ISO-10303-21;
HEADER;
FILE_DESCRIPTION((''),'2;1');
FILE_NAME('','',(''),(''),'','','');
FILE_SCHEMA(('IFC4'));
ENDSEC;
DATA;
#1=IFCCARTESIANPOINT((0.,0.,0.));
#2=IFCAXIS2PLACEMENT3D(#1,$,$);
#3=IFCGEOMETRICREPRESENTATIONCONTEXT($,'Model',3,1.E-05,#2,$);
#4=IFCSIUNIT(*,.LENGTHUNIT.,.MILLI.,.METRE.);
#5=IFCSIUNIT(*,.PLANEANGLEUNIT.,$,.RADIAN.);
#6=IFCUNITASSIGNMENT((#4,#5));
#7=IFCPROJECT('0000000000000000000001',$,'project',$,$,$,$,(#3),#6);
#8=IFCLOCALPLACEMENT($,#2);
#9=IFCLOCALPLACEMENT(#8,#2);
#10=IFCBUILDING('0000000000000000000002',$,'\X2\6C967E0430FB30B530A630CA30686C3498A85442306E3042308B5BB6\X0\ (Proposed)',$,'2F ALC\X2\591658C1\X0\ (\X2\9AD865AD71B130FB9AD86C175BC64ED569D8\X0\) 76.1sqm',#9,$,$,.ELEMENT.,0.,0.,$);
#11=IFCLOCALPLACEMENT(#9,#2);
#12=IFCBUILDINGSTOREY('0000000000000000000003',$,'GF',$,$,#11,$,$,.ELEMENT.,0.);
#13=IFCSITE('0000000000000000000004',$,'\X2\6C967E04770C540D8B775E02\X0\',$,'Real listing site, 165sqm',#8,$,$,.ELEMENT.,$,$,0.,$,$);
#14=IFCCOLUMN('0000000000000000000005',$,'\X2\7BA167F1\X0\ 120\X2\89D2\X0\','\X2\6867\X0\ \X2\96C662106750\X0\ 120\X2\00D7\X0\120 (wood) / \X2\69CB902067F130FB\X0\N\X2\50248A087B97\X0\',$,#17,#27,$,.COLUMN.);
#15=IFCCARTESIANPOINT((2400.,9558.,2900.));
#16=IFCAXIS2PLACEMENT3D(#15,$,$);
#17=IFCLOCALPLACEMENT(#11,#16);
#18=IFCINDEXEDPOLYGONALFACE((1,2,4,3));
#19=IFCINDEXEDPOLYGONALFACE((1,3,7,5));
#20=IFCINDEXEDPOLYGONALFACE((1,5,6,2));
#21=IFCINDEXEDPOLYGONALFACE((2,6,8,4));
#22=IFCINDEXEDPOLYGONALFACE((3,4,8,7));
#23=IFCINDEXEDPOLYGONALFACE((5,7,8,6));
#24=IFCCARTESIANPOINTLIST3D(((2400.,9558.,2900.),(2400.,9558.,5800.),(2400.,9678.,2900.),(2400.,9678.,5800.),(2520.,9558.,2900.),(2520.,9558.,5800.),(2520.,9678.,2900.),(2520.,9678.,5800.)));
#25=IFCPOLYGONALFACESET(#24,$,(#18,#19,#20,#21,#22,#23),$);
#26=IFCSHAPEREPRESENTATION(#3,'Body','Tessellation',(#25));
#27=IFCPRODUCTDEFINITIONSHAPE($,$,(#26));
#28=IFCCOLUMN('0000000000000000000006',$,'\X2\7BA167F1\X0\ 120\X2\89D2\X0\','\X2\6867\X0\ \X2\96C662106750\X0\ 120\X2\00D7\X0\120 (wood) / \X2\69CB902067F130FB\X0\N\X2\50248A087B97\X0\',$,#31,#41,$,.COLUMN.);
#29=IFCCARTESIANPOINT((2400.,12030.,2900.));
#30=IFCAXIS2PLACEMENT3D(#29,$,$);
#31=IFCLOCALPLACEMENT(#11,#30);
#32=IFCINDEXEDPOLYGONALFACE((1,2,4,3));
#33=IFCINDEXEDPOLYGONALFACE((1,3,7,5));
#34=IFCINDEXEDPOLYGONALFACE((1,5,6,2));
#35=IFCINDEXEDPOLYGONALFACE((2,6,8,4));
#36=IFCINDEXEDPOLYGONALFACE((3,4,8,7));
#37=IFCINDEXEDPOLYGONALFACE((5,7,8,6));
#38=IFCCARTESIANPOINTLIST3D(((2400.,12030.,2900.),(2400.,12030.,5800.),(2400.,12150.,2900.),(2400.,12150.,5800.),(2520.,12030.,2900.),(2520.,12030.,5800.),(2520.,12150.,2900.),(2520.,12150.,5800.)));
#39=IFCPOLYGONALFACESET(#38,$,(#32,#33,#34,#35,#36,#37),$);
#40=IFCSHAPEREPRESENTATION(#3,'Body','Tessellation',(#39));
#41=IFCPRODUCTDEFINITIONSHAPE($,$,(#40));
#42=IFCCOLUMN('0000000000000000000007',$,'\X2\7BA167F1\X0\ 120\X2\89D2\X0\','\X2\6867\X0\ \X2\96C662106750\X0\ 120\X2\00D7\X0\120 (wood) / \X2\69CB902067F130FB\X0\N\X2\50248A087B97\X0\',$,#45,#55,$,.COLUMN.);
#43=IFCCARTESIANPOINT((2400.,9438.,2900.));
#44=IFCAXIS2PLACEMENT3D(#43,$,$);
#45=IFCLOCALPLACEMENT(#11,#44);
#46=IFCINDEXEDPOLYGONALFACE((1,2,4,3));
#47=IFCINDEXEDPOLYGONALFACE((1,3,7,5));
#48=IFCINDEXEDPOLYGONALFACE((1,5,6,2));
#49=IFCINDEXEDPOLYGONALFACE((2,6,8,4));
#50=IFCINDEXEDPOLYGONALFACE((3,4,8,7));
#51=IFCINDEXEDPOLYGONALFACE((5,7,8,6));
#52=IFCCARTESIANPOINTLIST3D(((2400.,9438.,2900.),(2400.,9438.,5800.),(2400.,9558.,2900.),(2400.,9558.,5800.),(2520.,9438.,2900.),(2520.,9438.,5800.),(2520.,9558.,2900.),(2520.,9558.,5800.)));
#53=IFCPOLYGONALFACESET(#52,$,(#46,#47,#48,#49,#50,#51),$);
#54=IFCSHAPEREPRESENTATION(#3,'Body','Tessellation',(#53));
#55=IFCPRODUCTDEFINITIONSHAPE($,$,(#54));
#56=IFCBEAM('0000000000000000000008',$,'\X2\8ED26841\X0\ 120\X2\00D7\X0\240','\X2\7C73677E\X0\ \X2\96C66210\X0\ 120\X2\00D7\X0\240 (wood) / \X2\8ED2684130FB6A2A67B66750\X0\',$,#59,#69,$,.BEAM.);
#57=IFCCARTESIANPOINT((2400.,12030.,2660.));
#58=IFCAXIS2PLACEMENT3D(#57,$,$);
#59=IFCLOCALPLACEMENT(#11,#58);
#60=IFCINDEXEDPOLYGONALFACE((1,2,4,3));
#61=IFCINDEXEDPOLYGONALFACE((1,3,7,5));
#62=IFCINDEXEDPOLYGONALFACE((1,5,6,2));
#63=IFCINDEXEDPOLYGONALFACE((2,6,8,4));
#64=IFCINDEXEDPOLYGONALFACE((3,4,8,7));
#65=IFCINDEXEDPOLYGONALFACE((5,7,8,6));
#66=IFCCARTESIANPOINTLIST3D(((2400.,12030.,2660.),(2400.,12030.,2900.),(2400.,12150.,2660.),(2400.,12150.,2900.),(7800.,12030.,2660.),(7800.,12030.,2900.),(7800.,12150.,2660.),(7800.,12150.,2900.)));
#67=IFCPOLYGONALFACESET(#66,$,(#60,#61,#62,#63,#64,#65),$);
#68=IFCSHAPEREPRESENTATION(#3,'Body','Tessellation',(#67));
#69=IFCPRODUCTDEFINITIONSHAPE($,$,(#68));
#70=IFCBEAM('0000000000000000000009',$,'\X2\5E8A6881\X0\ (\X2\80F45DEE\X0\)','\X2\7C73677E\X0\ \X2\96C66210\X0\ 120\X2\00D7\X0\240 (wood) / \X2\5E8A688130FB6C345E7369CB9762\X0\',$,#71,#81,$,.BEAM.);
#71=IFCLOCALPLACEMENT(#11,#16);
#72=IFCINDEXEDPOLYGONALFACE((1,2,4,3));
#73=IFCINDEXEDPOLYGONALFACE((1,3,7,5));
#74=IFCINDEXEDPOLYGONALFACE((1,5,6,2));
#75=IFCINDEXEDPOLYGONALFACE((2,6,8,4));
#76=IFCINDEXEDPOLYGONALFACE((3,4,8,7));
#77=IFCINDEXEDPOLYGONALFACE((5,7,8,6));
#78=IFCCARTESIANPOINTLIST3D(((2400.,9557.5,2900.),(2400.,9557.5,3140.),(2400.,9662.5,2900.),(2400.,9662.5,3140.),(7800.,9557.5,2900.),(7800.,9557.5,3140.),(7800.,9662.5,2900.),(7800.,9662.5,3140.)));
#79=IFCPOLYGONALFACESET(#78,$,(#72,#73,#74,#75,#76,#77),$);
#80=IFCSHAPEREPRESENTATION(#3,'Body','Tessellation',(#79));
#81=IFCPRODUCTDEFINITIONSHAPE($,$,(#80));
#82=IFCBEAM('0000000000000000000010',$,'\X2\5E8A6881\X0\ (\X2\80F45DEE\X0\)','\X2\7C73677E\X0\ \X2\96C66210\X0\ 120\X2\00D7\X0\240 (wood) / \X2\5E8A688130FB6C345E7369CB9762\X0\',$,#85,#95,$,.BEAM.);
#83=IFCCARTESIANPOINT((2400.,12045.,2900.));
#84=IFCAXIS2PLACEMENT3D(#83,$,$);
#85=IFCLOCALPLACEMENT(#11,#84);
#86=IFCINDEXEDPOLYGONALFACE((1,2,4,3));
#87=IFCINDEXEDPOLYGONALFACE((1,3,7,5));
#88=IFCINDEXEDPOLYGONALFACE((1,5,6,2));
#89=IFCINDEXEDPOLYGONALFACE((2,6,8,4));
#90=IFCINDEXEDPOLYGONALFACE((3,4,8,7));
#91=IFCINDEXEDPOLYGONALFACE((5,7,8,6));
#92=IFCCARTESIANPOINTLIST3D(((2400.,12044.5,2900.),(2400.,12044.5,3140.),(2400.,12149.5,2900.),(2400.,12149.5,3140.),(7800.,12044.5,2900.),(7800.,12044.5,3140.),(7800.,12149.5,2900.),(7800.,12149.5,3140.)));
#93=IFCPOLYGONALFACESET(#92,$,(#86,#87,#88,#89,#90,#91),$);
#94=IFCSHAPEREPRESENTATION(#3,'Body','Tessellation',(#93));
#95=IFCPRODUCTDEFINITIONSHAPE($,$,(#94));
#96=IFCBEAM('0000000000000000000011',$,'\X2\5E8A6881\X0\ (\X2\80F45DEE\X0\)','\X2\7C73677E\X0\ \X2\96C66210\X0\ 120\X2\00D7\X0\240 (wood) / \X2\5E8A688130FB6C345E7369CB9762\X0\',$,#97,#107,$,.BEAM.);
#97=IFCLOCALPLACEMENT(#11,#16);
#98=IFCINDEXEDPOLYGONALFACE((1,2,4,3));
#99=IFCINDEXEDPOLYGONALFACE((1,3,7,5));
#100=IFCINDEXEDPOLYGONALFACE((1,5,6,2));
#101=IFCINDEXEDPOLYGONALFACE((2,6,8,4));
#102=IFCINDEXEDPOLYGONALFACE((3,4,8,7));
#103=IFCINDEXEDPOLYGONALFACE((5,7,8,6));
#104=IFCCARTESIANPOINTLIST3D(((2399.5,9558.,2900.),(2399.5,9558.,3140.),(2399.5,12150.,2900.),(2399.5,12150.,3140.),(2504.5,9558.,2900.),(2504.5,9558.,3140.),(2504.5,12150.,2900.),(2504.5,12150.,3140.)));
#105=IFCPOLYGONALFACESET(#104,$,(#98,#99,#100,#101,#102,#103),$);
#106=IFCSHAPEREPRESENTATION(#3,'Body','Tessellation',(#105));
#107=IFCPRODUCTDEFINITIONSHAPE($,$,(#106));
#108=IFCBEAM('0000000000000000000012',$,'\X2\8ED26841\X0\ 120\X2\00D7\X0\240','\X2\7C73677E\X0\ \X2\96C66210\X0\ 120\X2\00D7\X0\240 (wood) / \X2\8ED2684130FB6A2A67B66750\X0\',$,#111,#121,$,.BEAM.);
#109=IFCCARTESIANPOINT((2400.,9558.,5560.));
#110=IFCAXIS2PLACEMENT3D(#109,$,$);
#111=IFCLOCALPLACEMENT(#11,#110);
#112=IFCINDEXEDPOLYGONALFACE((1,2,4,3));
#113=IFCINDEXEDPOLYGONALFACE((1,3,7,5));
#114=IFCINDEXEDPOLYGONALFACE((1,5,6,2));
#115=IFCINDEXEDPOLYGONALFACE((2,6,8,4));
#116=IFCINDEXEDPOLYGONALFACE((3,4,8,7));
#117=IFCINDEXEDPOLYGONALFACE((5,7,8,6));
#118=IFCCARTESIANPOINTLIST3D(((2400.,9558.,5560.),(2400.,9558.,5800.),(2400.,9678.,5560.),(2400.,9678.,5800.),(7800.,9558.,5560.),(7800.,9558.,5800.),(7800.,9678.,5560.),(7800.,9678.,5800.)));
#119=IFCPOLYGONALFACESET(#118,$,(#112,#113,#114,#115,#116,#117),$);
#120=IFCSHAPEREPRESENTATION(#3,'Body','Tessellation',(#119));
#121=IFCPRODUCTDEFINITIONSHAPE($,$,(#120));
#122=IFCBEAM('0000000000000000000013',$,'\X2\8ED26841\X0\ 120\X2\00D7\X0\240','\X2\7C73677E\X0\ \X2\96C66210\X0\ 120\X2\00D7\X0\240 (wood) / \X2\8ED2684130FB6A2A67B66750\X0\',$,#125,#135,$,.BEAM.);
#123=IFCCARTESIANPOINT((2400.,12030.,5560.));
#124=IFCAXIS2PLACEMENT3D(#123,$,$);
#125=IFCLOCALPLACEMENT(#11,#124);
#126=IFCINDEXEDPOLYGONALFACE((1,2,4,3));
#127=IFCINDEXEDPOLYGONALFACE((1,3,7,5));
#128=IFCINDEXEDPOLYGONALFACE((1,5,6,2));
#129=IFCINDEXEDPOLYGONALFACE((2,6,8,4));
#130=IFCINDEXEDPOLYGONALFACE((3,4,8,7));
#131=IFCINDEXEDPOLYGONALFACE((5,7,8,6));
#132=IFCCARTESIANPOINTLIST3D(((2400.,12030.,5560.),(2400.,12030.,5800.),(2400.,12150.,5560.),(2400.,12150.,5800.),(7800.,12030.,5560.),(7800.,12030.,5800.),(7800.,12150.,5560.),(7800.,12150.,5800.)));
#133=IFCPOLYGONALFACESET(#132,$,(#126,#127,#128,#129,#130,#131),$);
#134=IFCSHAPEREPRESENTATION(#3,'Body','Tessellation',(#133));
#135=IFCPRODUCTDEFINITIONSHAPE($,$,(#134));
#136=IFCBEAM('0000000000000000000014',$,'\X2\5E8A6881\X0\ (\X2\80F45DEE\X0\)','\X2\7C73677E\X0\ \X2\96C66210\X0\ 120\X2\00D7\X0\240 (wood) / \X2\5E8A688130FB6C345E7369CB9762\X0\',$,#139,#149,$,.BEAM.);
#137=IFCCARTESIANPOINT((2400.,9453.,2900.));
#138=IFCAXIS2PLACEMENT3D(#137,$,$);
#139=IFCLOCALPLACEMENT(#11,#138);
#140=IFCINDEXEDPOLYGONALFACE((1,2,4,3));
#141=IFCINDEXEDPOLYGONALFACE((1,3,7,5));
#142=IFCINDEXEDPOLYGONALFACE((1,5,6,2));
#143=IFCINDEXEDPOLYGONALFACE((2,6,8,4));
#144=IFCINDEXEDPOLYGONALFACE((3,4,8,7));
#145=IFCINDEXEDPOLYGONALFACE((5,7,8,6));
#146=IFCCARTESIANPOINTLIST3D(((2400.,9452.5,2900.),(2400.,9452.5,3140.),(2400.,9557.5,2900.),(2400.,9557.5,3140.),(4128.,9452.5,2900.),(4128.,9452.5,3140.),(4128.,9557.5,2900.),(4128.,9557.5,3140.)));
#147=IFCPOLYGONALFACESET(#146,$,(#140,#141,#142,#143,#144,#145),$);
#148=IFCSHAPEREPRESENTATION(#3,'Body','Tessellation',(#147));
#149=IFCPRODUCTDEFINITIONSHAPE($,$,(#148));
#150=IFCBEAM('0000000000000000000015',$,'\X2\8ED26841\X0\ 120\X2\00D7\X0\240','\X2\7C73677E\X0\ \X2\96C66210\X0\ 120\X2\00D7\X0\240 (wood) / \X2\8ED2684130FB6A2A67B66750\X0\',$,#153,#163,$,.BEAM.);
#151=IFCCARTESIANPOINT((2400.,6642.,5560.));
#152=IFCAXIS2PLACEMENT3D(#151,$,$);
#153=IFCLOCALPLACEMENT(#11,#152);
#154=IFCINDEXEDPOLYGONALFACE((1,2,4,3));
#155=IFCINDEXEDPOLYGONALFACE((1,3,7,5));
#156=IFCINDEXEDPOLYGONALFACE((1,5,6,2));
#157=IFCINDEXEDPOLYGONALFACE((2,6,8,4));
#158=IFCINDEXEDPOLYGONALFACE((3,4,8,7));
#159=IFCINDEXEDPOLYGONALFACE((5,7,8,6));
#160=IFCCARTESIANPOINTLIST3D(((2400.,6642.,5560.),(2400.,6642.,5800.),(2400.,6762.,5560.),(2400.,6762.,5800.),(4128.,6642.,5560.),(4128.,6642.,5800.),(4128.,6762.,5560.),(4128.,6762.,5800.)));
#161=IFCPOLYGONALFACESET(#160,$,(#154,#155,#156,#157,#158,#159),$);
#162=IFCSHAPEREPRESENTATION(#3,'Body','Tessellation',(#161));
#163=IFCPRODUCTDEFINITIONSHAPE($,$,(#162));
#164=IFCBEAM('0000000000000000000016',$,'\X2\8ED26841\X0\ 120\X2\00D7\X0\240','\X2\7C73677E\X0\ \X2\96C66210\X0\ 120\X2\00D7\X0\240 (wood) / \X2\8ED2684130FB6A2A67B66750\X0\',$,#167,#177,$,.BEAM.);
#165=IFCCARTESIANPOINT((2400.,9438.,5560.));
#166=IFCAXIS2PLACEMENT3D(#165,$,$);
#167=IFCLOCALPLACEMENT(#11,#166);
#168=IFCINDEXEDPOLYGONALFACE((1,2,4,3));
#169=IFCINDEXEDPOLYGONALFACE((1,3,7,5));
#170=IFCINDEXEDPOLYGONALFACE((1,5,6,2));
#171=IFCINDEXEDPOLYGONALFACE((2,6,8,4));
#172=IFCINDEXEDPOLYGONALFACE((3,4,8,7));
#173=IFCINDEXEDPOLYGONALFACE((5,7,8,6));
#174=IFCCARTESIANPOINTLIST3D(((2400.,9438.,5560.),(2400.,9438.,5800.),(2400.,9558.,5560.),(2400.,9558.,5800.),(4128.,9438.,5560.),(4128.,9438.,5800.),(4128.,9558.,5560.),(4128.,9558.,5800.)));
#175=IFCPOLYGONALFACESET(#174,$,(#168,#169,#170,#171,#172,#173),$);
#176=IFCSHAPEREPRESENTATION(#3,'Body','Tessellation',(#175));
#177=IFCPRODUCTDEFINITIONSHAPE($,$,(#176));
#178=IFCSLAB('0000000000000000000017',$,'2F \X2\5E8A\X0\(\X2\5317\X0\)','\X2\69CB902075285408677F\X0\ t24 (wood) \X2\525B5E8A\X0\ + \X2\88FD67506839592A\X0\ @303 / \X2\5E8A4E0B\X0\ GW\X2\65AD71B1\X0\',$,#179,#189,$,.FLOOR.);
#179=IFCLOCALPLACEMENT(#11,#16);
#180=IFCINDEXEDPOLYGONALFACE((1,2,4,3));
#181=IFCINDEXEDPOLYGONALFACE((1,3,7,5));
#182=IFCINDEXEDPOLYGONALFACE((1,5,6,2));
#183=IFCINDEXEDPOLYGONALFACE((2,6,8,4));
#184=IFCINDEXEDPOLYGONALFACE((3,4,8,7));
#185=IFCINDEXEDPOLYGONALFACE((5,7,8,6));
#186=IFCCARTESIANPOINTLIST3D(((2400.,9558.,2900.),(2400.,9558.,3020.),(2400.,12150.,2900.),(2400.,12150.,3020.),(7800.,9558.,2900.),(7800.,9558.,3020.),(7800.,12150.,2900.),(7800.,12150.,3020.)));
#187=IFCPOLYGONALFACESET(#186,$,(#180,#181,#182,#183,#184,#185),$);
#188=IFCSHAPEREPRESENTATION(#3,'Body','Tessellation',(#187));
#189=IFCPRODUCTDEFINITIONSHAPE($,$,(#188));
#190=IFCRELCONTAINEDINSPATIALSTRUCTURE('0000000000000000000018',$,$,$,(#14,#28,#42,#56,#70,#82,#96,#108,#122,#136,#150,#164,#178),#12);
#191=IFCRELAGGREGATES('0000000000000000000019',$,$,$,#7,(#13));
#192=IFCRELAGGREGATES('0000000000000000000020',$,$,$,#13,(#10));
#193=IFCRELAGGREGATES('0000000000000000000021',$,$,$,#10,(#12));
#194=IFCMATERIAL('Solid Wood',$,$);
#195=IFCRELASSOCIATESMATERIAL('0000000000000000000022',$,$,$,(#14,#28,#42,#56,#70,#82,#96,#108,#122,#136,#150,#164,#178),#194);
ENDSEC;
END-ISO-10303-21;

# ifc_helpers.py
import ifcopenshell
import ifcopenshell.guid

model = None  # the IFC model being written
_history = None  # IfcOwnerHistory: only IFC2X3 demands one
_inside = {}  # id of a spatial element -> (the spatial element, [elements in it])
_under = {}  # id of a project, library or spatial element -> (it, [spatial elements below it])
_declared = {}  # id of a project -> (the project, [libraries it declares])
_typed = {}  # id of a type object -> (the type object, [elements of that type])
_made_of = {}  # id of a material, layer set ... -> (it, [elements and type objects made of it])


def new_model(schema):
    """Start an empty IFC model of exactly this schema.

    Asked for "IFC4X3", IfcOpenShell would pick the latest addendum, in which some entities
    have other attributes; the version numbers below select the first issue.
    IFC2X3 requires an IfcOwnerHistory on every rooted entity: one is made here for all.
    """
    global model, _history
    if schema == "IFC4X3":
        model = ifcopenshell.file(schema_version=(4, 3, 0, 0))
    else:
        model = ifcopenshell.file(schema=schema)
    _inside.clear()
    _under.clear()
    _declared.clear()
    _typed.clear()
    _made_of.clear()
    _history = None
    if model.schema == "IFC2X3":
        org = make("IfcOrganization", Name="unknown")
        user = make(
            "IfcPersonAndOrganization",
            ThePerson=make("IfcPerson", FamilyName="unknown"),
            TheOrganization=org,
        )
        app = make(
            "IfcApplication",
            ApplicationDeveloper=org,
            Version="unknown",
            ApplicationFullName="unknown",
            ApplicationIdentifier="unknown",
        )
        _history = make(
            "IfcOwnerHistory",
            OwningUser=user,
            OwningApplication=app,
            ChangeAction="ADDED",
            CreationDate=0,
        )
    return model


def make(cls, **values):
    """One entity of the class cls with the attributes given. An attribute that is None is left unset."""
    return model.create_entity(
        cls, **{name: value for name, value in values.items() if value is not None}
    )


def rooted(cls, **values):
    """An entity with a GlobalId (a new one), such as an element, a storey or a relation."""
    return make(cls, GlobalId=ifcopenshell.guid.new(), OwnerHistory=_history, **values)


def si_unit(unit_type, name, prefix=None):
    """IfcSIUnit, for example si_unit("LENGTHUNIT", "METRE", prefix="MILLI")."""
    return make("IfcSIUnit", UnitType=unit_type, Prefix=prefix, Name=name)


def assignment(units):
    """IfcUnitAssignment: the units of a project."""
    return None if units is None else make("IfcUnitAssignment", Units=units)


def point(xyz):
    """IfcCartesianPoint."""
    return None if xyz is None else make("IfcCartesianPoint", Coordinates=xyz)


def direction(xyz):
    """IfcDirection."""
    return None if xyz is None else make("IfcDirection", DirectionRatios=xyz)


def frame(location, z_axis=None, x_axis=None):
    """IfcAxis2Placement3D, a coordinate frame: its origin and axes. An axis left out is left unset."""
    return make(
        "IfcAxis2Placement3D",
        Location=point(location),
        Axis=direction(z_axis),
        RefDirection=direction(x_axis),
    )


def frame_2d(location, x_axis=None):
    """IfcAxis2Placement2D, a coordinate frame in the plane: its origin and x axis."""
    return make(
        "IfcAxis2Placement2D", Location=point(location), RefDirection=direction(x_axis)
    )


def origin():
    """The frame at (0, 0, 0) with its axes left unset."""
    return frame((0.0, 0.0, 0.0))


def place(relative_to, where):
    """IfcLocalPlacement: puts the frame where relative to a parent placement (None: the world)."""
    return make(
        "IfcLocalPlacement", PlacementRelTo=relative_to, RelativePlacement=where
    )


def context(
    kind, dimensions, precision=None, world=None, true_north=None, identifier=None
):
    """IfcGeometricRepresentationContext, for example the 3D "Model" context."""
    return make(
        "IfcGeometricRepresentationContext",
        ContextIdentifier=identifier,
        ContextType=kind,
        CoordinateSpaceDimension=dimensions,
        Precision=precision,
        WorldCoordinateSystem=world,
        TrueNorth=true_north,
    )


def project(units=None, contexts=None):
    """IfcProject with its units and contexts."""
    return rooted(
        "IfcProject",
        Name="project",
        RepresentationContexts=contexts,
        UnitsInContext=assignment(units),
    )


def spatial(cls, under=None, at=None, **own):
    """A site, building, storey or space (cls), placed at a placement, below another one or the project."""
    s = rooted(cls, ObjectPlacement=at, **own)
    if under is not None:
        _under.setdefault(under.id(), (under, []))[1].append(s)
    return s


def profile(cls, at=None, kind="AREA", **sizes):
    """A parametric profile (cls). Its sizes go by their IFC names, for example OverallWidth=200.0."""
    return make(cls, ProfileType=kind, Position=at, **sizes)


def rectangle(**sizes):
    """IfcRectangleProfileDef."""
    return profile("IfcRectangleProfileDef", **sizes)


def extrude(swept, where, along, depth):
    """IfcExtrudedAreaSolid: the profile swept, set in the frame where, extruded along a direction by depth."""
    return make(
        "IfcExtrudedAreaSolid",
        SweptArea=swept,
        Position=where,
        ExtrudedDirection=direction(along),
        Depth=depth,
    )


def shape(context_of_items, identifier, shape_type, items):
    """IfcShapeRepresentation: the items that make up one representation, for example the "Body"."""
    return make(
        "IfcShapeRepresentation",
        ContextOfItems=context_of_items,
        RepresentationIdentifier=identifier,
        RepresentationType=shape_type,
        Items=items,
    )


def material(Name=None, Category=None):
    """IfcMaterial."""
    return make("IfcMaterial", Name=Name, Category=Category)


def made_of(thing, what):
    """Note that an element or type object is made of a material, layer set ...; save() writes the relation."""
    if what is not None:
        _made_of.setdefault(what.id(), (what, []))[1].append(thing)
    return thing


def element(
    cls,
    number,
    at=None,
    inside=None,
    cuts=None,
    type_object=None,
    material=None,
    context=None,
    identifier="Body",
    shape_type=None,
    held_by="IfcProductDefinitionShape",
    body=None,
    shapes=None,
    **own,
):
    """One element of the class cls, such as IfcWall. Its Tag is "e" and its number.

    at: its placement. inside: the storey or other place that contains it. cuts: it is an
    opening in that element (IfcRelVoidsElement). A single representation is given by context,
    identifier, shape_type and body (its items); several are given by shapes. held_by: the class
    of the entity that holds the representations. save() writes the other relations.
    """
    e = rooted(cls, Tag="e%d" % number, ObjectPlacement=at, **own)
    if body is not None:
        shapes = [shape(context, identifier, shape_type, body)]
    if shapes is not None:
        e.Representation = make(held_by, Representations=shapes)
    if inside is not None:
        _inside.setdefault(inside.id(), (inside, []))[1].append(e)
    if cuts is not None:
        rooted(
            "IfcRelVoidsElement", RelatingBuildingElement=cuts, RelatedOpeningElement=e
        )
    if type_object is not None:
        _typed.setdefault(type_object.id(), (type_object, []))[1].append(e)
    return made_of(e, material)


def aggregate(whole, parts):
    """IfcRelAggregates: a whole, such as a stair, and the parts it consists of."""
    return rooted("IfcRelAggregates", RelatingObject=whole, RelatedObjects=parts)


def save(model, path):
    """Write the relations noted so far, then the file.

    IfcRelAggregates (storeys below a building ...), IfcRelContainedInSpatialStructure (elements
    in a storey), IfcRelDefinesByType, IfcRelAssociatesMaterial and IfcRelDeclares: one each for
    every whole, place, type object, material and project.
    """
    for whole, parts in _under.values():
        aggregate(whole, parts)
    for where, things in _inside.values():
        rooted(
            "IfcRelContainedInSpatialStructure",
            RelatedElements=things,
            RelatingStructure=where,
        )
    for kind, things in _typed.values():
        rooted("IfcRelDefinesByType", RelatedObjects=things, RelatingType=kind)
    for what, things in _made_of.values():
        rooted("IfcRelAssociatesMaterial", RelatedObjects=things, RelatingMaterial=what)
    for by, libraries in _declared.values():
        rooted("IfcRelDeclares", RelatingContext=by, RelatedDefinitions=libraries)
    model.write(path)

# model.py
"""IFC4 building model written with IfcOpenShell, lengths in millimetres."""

from ifc_helpers import new_model, si_unit, frame, frame_2d, origin, place, context, project, spatial, rectangle, extrude, material, element, save


model = new_model("IFC4")

# Units and contexts
model_context = context("Model", 3, precision=1e-05, world=origin())
ifc_project = project(units=[si_unit("LENGTHUNIT", "METRE", prefix="MILLI"), si_unit("PLANEANGLEUNIT", "RADIAN")], contexts=[model_context])

# Site, building, storey
site_placement = place(None, origin())
site = spatial("IfcSite", under=ifc_project, at=site_placement, Name="沖縄県名護市", ObjectType="Real listing site, 165sqm", CompositionType="ELEMENT", RefElevation=0.0)
building_placement = place(site_placement, origin())
building = spatial("IfcBuilding", under=site, at=building_placement, Name="沖縄・サウナと水風呂のある家 (Proposed)", ObjectType="2F ALC外壁 (高断熱・高気密仕様) 76.1sqm", CompositionType="ELEMENT", ElevationOfRefHeight=0.0, ElevationOfTerrain=0.0)
storey_placement = place(building_placement, origin())
storey = spatial("IfcBuildingStorey", under=building, at=storey_placement, Name="GF", CompositionType="ELEMENT", Elevation=0.0)

# Columns
ifc_material_1 = material(Name="Solid Wood")
column_1_placement = place(storey_placement, frame((2400.0, 9558.0, 2900.0)))
element("IfcColumn", 1, at=column_1_placement, inside=storey, material=ifc_material_1, Name="管柱 120角", Description="桧 集成材 120×120 (wood) / 構造柱・N値計算", PredefinedType="COLUMN", context=model_context, shape_type="SweptSolid", body=[
    extrude(rectangle(XDim=120.0, YDim=120.0, at=frame_2d((60.0, 60.0))), frame((2400.0, 9558.0, 2900.0)), (0.0, 0.0, 1.0), 2900.0),
])
column_2_placement = place(storey_placement, frame((2400.0, 12030.0, 2900.0)))
element("IfcColumn", 2, at=column_2_placement, inside=storey, material=ifc_material_1, Name="管柱 120角", Description="桧 集成材 120×120 (wood) / 構造柱・N値計算", PredefinedType="COLUMN", context=model_context, shape_type="SweptSolid", body=[
    extrude(rectangle(XDim=120.0, YDim=120.0, at=frame_2d((60.0, 60.0))), frame((2400.0, 12030.0, 2900.0)), (0.0, 0.0, 1.0), 2900.0),
])
column_3_placement = place(storey_placement, frame((2400.0, 9438.0, 2900.0)))
element("IfcColumn", 3, at=column_3_placement, inside=storey, material=ifc_material_1, Name="管柱 120角", Description="桧 集成材 120×120 (wood) / 構造柱・N値計算", PredefinedType="COLUMN", context=model_context, shape_type="SweptSolid", body=[
    extrude(rectangle(XDim=120.0, YDim=120.0, at=frame_2d((60.0, 60.0))), frame((2400.0, 9438.0, 2900.0)), (0.0, 0.0, 1.0), 2900.0),
])

# Beams
beam_1_placement = place(storey_placement, frame((2400.0, 12030.0, 2660.0)))
element("IfcBeam", 4, at=beam_1_placement, inside=storey, material=ifc_material_1, Name="軒桁 120×240", Description="米松 集成 120×240 (wood) / 軒桁・横架材", PredefinedType="BEAM", context=model_context, shape_type="SweptSolid", body=[
    extrude(rectangle(XDim=5400.0, YDim=120.0, at=frame_2d((2700.0, 60.0))), frame((2400.0, 12030.0, 2660.0)), (0.0, 0.0, 1.0), 240.0),
])
beam_2_placement = place(storey_placement, frame((2400.0, 9558.0, 2900.0)))
element("IfcBeam", 5, at=beam_2_placement, inside=storey, material=ifc_material_1, Name="床梁 (胴差)", Description="米松 集成 120×240 (wood) / 床梁・水平構面", PredefinedType="BEAM", context=model_context, shape_type="SweptSolid", body=[
    extrude(rectangle(XDim=5400.0, YDim=105.0, at=frame_2d((2700.0, 52.0))), frame((2400.0, 9558.0, 2900.0)), (0.0, 0.0, 1.0), 240.0),
])
beam_3_placement = place(storey_placement, frame((2400.0, 12045.0, 2900.0)))
element("IfcBeam", 6, at=beam_3_placement, inside=storey, material=ifc_material_1, Name="床梁 (胴差)", Description="米松 集成 120×240 (wood) / 床梁・水平構面", PredefinedType="BEAM", context=model_context, shape_type="SweptSolid", body=[
    extrude(rectangle(XDim=5400.0, YDim=105.0, at=frame_2d((2700.0, 52.0))), frame((2400.0, 12045.0, 2900.0)), (0.0, 0.0, 1.0), 240.0),
])
beam_4_placement = place(storey_placement, frame((2400.0, 9558.0, 2900.0)))
element("IfcBeam", 7, at=beam_4_placement, inside=storey, material=ifc_material_1, Name="床梁 (胴差)", Description="米松 集成 120×240 (wood) / 床梁・水平構面", PredefinedType="BEAM", context=model_context, shape_type="SweptSolid", body=[
    extrude(rectangle(XDim=105.0, YDim=2592.0, at=frame_2d((52.0, 1296.0))), frame((2400.0, 9558.0, 2900.0)), (0.0, 0.0, 1.0), 240.0),
])
beam_5_placement = place(storey_placement, frame((2400.0, 9558.0, 5560.0)))
element("IfcBeam", 8, at=beam_5_placement, inside=storey, material=ifc_material_1, Name="軒桁 120×240", Description="米松 集成 120×240 (wood) / 軒桁・横架材", PredefinedType="BEAM", context=model_context, shape_type="SweptSolid", body=[
    extrude(rectangle(XDim=5400.0, YDim=120.0, at=frame_2d((2700.0, 60.0))), frame((2400.0, 9558.0, 5560.0)), (0.0, 0.0, 1.0), 240.0),
])
beam_6_placement = place(storey_placement, frame((2400.0, 12030.0, 5560.0)))
element("IfcBeam", 9, at=beam_6_placement, inside=storey, material=ifc_material_1, Name="軒桁 120×240", Description="米松 集成 120×240 (wood) / 軒桁・横架材", PredefinedType="BEAM", context=model_context, shape_type="SweptSolid", body=[
    extrude(rectangle(XDim=5400.0, YDim=120.0, at=frame_2d((2700.0, 60.0))), frame((2400.0, 12030.0, 5560.0)), (0.0, 0.0, 1.0), 240.0),
])
beam_7_placement = place(storey_placement, frame((2400.0, 9453.0, 2900.0)))
element("IfcBeam", 10, at=beam_7_placement, inside=storey, material=ifc_material_1, Name="床梁 (胴差)", Description="米松 集成 120×240 (wood) / 床梁・水平構面", PredefinedType="BEAM", context=model_context, shape_type="SweptSolid", body=[
    extrude(rectangle(XDim=1728.0, YDim=105.0, at=frame_2d((864.0, 52.0))), frame((2400.0, 9453.0, 2900.0)), (0.0, 0.0, 1.0), 240.0),
])
beam_8_placement = place(storey_placement, frame((2400.0, 6642.0, 5560.0)))
element("IfcBeam", 11, at=beam_8_placement, inside=storey, material=ifc_material_1, Name="軒桁 120×240", Description="米松 集成 120×240 (wood) / 軒桁・横架材", PredefinedType="BEAM", context=model_context, shape_type="SweptSolid", body=[
    extrude(rectangle(XDim=1728.0, YDim=120.0, at=frame_2d((864.0, 60.0))), frame((2400.0, 6642.0, 5560.0)), (0.0, 0.0, 1.0), 240.0),
])
beam_9_placement = place(storey_placement, frame((2400.0, 9438.0, 5560.0)))
element("IfcBeam", 12, at=beam_9_placement, inside=storey, material=ifc_material_1, Name="軒桁 120×240", Description="米松 集成 120×240 (wood) / 軒桁・横架材", PredefinedType="BEAM", context=model_context, shape_type="SweptSolid", body=[
    extrude(rectangle(XDim=1728.0, YDim=120.0, at=frame_2d((864.0, 60.0))), frame((2400.0, 9438.0, 5560.0)), (0.0, 0.0, 1.0), 240.0),
])

# Slab
slab_placement = place(storey_placement, frame((2400.0, 9558.0, 2900.0)))
element("IfcSlab", 13, at=slab_placement, inside=storey, material=ifc_material_1, Name="2F 床(北)", Description="構造用合板 t24 (wood) 剛床 + 製材根太 @303 / 床下 GW断熱", PredefinedType="FLOOR", context=model_context, shape_type="SweptSolid", body=[
    extrude(rectangle(XDim=5400.0, YDim=2592.0, at=frame_2d((2700.0, 1296.0))), frame((2400.0, 9558.0, 2900.0)), (0.0, 0.0, 1.0), 120.0),
])

save(model, "model.ifc")
